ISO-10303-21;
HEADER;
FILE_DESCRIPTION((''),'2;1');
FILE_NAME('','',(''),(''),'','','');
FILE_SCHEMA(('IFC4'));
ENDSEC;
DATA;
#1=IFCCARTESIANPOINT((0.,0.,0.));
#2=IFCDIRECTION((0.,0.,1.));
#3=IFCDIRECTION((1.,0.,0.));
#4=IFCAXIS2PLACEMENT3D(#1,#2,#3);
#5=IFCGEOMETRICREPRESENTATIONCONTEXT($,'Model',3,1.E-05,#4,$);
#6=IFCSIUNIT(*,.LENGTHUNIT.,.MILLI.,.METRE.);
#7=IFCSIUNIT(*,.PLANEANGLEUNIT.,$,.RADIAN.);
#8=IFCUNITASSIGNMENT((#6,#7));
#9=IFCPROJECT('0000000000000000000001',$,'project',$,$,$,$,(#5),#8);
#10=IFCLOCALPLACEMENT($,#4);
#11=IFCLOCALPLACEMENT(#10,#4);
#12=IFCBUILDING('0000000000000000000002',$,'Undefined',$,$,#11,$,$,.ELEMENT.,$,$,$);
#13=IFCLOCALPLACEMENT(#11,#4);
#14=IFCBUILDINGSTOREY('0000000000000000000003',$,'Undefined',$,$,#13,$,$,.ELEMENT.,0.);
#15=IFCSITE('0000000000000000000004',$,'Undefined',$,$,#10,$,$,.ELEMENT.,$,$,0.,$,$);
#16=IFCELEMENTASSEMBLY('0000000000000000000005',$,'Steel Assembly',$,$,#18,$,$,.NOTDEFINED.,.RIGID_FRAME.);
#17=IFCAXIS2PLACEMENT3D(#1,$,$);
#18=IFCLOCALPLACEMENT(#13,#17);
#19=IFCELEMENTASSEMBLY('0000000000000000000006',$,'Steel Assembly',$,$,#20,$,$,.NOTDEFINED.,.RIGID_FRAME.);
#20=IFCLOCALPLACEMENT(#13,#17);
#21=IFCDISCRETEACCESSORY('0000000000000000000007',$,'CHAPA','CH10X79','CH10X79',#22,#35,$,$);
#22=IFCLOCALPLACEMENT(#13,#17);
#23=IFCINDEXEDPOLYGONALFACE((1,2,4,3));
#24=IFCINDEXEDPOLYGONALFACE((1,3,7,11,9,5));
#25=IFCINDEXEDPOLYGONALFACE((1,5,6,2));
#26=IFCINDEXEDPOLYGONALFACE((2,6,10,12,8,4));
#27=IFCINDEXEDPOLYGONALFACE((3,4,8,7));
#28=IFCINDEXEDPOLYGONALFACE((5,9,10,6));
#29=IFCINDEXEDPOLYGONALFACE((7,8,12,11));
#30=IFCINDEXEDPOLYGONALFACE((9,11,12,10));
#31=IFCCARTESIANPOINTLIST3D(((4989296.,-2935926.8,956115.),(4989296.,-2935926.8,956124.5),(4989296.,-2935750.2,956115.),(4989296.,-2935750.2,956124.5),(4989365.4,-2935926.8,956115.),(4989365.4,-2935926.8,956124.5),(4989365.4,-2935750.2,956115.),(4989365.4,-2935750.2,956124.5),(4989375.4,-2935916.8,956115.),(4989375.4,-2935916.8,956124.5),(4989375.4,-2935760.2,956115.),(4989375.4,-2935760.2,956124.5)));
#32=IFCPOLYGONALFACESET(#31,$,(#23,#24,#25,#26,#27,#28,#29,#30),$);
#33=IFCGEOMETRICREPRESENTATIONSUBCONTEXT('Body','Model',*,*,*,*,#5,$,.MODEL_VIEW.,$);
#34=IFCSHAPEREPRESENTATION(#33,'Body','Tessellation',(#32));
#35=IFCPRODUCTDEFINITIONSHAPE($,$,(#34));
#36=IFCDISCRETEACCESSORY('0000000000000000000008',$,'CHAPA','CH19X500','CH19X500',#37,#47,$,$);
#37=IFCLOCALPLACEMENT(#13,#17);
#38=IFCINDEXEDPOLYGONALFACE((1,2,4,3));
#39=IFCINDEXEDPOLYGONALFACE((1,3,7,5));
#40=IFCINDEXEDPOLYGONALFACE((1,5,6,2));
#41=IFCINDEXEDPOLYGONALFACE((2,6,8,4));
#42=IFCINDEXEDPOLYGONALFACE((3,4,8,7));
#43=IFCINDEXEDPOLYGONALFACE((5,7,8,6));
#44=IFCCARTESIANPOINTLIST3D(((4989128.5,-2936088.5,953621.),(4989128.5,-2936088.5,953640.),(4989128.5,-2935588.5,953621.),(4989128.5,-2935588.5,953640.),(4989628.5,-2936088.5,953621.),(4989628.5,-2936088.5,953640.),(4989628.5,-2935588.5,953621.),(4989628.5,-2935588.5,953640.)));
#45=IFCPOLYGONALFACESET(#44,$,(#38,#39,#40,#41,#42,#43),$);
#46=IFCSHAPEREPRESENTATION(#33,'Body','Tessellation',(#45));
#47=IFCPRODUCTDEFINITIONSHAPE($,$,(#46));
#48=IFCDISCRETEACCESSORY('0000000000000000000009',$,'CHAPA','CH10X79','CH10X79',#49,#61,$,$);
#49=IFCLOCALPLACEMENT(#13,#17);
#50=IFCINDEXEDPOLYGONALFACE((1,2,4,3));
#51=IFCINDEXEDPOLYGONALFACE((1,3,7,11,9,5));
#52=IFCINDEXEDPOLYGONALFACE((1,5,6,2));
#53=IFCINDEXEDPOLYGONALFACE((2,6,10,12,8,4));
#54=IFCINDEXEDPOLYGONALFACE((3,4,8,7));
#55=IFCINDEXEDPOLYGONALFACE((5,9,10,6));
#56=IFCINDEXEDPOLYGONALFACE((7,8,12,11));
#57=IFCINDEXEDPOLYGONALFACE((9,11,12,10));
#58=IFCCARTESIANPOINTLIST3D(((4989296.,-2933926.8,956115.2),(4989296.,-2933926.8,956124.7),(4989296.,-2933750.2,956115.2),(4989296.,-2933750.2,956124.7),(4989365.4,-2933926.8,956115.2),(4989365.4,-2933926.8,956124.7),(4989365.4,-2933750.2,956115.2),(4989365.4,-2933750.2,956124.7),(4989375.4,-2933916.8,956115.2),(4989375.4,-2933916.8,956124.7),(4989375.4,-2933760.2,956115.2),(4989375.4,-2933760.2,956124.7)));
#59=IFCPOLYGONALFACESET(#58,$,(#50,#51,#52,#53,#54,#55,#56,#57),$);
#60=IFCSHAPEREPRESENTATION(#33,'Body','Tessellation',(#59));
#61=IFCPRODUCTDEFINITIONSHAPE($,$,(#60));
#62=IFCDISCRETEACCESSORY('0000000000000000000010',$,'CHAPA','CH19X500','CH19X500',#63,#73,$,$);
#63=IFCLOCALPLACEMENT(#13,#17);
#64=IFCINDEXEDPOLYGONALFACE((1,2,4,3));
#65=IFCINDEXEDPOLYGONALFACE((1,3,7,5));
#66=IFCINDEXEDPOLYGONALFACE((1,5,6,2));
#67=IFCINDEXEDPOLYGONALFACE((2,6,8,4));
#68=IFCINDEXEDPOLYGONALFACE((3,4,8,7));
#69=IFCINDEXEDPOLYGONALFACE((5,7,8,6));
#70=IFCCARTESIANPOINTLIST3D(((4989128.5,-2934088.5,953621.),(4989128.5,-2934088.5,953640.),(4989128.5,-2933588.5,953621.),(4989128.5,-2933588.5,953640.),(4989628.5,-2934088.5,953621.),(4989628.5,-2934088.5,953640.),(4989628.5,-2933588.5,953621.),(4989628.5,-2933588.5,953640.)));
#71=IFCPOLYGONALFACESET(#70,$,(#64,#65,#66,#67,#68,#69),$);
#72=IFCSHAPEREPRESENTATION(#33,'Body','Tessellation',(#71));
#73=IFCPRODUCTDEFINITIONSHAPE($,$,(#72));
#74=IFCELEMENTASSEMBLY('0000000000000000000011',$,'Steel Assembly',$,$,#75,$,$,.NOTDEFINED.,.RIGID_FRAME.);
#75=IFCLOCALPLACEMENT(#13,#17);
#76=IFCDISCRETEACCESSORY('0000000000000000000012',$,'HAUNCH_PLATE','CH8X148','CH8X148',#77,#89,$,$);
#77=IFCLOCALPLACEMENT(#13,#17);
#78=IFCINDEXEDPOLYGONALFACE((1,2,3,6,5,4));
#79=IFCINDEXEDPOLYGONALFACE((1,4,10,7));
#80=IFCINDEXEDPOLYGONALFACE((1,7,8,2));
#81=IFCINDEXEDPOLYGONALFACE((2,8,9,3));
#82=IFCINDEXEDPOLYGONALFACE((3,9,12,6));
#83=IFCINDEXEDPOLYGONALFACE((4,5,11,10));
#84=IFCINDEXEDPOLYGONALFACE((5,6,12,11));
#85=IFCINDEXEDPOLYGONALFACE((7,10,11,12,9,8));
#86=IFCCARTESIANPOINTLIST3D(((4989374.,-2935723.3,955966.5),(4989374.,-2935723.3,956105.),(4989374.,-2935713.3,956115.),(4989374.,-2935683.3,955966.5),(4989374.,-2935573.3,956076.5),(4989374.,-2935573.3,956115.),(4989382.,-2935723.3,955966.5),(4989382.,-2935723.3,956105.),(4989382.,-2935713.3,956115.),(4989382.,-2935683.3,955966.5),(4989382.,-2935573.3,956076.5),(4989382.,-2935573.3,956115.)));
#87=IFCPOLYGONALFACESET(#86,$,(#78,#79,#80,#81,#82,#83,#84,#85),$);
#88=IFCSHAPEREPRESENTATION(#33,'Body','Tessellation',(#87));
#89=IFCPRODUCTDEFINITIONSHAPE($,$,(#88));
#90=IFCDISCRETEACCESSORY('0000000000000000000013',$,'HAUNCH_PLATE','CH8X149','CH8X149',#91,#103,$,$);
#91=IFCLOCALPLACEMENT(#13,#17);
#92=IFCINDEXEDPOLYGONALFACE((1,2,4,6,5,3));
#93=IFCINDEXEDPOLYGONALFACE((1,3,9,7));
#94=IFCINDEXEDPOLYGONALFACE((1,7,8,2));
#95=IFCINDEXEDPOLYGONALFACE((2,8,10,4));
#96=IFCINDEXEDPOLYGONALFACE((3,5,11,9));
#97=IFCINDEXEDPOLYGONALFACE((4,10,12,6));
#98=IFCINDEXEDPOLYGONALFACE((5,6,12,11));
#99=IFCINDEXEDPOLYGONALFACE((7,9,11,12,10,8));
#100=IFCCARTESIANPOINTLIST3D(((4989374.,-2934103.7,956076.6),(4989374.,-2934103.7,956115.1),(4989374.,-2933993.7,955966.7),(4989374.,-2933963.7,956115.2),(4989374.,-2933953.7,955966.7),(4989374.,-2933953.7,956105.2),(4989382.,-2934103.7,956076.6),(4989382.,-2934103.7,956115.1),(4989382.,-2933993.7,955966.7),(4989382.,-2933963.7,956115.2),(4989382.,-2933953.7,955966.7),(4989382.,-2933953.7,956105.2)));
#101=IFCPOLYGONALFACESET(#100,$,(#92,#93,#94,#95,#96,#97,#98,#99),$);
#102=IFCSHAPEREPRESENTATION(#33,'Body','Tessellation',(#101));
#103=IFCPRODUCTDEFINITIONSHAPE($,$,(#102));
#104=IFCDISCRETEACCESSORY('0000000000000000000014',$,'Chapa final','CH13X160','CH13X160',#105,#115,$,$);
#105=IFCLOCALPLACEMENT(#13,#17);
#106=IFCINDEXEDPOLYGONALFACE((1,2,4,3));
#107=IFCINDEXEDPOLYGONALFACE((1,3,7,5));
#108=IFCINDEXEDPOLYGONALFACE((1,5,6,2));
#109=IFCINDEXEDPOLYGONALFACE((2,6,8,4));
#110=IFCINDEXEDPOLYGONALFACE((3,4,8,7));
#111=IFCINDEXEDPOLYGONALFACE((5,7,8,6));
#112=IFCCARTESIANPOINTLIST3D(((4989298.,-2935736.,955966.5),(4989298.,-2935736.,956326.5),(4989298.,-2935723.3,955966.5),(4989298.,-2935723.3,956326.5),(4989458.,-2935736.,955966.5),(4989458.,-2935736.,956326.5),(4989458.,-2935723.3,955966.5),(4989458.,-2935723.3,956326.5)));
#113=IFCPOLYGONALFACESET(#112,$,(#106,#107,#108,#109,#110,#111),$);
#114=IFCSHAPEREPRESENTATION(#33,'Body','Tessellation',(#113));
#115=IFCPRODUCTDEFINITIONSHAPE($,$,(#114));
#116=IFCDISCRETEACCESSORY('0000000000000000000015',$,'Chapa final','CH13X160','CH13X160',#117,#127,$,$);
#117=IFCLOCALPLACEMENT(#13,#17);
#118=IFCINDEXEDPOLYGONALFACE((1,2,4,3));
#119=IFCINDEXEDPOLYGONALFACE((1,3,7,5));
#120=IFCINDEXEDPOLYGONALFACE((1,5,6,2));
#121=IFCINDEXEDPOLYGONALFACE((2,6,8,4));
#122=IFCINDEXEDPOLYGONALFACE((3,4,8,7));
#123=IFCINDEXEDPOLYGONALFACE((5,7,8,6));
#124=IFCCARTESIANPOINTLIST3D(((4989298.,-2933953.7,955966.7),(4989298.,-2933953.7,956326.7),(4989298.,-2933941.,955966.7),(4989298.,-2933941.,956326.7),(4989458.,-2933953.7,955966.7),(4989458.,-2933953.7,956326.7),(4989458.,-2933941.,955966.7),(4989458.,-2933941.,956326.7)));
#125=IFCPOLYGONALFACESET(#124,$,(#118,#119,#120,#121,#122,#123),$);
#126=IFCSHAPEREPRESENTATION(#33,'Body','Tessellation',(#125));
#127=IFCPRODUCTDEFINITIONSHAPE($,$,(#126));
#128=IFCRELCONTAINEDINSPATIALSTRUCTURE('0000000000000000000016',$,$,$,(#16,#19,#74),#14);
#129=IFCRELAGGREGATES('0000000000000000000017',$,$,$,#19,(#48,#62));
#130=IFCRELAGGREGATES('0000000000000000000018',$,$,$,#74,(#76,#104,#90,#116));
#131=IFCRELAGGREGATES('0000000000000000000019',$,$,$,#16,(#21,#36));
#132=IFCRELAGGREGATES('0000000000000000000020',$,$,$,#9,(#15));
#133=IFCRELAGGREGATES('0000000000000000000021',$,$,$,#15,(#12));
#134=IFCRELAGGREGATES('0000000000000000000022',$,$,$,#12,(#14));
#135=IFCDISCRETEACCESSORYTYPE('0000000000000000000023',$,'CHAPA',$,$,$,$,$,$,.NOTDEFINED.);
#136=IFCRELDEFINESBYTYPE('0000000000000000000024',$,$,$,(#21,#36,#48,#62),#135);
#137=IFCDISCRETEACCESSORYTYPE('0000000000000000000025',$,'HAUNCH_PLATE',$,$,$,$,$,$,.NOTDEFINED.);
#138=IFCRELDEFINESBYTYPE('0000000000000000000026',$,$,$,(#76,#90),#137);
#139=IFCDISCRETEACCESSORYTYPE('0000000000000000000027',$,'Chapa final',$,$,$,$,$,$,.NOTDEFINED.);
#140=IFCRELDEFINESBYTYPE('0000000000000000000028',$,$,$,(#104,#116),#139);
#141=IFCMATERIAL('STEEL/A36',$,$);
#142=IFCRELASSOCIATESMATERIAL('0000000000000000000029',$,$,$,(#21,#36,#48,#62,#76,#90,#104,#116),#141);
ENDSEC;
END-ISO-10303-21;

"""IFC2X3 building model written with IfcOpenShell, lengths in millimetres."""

from ifc_helpers import new_model, si_unit, frame, origin_with_axes, place, context, subcontext, project, spatial, polyline, outline, extrude, material, type_object, element, aggregate, save


model = new_model("IFC2X3")

# Units and contexts
model_context = context("Model", 3, precision=1e-05, world=origin_with_axes())
body_context = subcontext(model_context, "Body", "Model", "MODEL_VIEW")
ifc_project = project(units=[si_unit("LENGTHUNIT", "METRE", prefix="MILLI"), si_unit("PLANEANGLEUNIT", "RADIAN")], contexts=[model_context])

# Site, building, storey
site_placement = place(None, origin_with_axes())
site = spatial("IfcSite", under=ifc_project, at=site_placement, Name="Undefined", CompositionType="ELEMENT", RefElevation=0.0)
building_placement = place(site_placement, origin_with_axes())
building = spatial("IfcBuilding", under=site, at=building_placement, Name="Undefined", CompositionType="ELEMENT")
storey_placement = place(building_placement, origin_with_axes())
storey = spatial("IfcBuildingStorey", under=building, at=storey_placement, Name="Undefined", CompositionType="ELEMENT", Elevation=0.0)

# Element assemblies
assembly_1_placement = place(storey_placement, origin_with_axes())
assembly_1 = element("IfcElementAssembly", 1, at=assembly_1_placement, inside=storey, Name="Steel Assembly", AssemblyPlace="NOTDEFINED", PredefinedType="RIGID_FRAME")
assembly_2_placement = place(storey_placement, origin_with_axes())
assembly_2 = element("IfcElementAssembly", 2, at=assembly_2_placement, inside=storey, Name="Steel Assembly", AssemblyPlace="NOTDEFINED", PredefinedType="RIGID_FRAME")

# Discrete accessories
ifc_material_1 = material(Name="STEEL/A36")
discrete_accessory_type_1 = type_object("IfcDiscreteAccessoryType", Name="CHAPA")
discrete_accessory_1_placement = place(assembly_1_placement, frame((4989296.0, -2935750.2, 956119.8), z_axis=(0.0, 0.0, -1.0), x_axis=(1.0, 0.0, 0.0)))
discrete_accessory_1 = element("IfcDiscreteAccessory", 3, at=discrete_accessory_1_placement, type_object=discrete_accessory_type_1, material=ifc_material_1, Name="CHAPA", Description="CH10X79", ObjectType="CH10X79", context=body_context, shape_type="SweptSolid", body=[
    extrude(outline(polyline([(0.0, 0.0), (69.4, 0.0), (79.4, 10.0), (79.4, 166.6), (69.4, 176.6), (0.0, 176.6), (0.0, 0.0)])), frame((0.0, 0.0, -4.8), z_axis=(0.0, 0.0, 1.0), x_axis=(1.0, 0.0, 0.0)), (0.0, 0.0, 1.0), 9.5),
])
discrete_accessory_2_placement = place(assembly_1_placement, frame((4989378.5, -2935588.5, 953630.5), z_axis=(0.0, 0.0, 1.0), x_axis=(0.0, -1.0, 0.0)))
discrete_accessory_2 = element("IfcDiscreteAccessory", 4, at=discrete_accessory_2_placement, type_object=discrete_accessory_type_1, material=ifc_material_1, Name="CHAPA", Description="CH19X500", ObjectType="CH19X500", context=body_context, shape_type="SweptSolid", body=[
    extrude(outline(polyline([(500.0, -250.0), (0.0, -250.0), (0.0, 250.0), (500.0, 250.0), (500.0, -250.0)])), frame((0.0, 0.0, -9.5), z_axis=(0.0, 0.0, 1.0), x_axis=(1.0, 0.0, 0.0)), (0.0, 0.0, 1.0), 19.0),
])
discrete_accessory_3_placement = place(assembly_2_placement, frame((4989375.4, -2933926.8, 956119.9), z_axis=(0.0, 0.0, -1.0), x_axis=(-1.0, 0.0, 0.0)))
discrete_accessory_3 = element("IfcDiscreteAccessory", 5, at=discrete_accessory_3_placement, type_object=discrete_accessory_type_1, material=ifc_material_1, Name="CHAPA", Description="CH10X79", ObjectType="CH10X79", context=body_context, shape_type="SweptSolid", body=[
    extrude(outline(polyline([(0.0, 10.0), (10.0, 0.0), (79.4, 0.0), (79.4, 176.6), (10.0, 176.6), (0.0, 166.6), (0.0, 10.0)])), frame((0.0, 0.0, -4.8), z_axis=(0.0, 0.0, 1.0), x_axis=(1.0, 0.0, 0.0)), (0.0, 0.0, 1.0), 9.5),
])
discrete_accessory_4_placement = place(assembly_2_placement, frame((4989378.5, -2933588.5, 953630.5), z_axis=(0.0, 0.0, 1.0), x_axis=(0.0, -1.0, 0.0)))
discrete_accessory_4 = element("IfcDiscreteAccessory", 6, at=discrete_accessory_4_placement, type_object=discrete_accessory_type_1, material=ifc_material_1, Name="CHAPA", Description="CH19X500", ObjectType="CH19X500", context=body_context, shape_type="SweptSolid", body=[
    extrude(outline(polyline([(500.0, -250.0), (0.0, -250.0), (0.0, 250.0), (500.0, 250.0), (500.0, -250.0)])), frame((0.0, 0.0, -9.5), z_axis=(0.0, 0.0, 1.0), x_axis=(1.0, 0.0, 0.0)), (0.0, 0.0, 1.0), 19.0),
])
aggregate(assembly_2, [discrete_accessory_3, discrete_accessory_4])

# Element assembly, discrete accessories
assembly_3_placement = place(storey_placement, origin_with_axes())
assembly_3 = element("IfcElementAssembly", 7, at=assembly_3_placement, inside=storey, Name="Steel Assembly", AssemblyPlace="NOTDEFINED", PredefinedType="RIGID_FRAME")
discrete_accessory_type_2 = type_object("IfcDiscreteAccessoryType", Name="HAUNCH_PLATE")
discrete_accessory_5_placement = place(assembly_3_placement, frame((4989378.0, -2935723.3, 956115.0), z_axis=(1.0, 0.0, 0.0), x_axis=(0.0, 0.0, -1.0)))
discrete_accessory_5 = element("IfcDiscreteAccessory", 8, at=discrete_accessory_5_placement, type_object=discrete_accessory_type_2, material=ifc_material_1, Name="HAUNCH_PLATE", Description="CH8X148", ObjectType="CH8X148", context=body_context, shape_type="SweptSolid", body=[
    extrude(outline(polyline([(0.0, 10.0), (10.0, 0.0), (148.5, 0.0), (148.5, 40.0), (38.5, 150.0), (0.0, 150.0), (0.0, 10.0)])), frame((0.0, 0.0, -4.0), z_axis=(0.0, 0.0, 1.0), x_axis=(1.0, 0.0, 0.0)), (0.0, 0.0, 1.0), 8.0),
])
discrete_accessory_6_placement = place(assembly_3_placement, frame((4989378.0, -2933953.7, 956115.2), z_axis=(-1.0, 0.0, 0.0), x_axis=(0.0, 0.0, -1.0)))
discrete_accessory_6 = element("IfcDiscreteAccessory", 9, at=discrete_accessory_6_placement, type_object=discrete_accessory_type_2, material=ifc_material_1, Name="HAUNCH_PLATE", Description="CH8X149", ObjectType="CH8X149", context=body_context, shape_type="SweptSolid", body=[
    extrude(outline(polyline([(0.0, 10.0), (10.0, 0.0), (148.5, 0.0), (148.5, 40.0), (38.5, 150.0), (0.0, 150.0), (0.0, 10.0)])), frame((0.0, 0.0, -4.0), z_axis=(0.0, 0.0, 1.0), x_axis=(1.0, 0.0, 0.0)), (0.0, 0.0, 1.0), 8.0),
])
discrete_accessory_type_3 = type_object("IfcDiscreteAccessoryType", Name="Chapa final")
discrete_accessory_7_placement = place(assembly_3_placement, frame((4989378.0, -2935729.7, 955966.5), z_axis=(0.0, 1.0, 0.0), x_axis=(0.0, 0.0, 1.0)))
discrete_accessory_7 = element("IfcDiscreteAccessory", 10, at=discrete_accessory_7_placement, type_object=discrete_accessory_type_3, material=ifc_material_1, Name="Chapa final", Description="CH13X160", ObjectType="CH13X160", context=body_context, shape_type="SweptSolid", body=[
    extrude(outline(polyline([(0.0, -80.0), (0.0, 80.0), (360.0, 80.0), (360.0, -80.0), (0.0, -80.0)])), frame((0.0, 0.0, -6.3), z_axis=(0.0, 0.0, 1.0), x_axis=(1.0, 0.0, 0.0)), (0.0, 0.0, 1.0), 12.7),
])
discrete_accessory_8_placement = place(assembly_3_placement, frame((4989378.0, -2933947.4, 955966.7), z_axis=(0.0, -1.0, 0.0), x_axis=(0.0, 0.0, 1.0)))
discrete_accessory_8 = element("IfcDiscreteAccessory", 11, at=discrete_accessory_8_placement, type_object=discrete_accessory_type_3, material=ifc_material_1, Name="Chapa final", Description="CH13X160", ObjectType="CH13X160", context=body_context, shape_type="SweptSolid", body=[
    extrude(outline(polyline([(0.0, 80.0), (360.0, 80.0), (360.0, -80.0), (0.0, -80.0), (0.0, 80.0)])), frame((0.0, 0.0, -6.3), z_axis=(0.0, 0.0, 1.0), x_axis=(1.0, 0.0, 0.0)), (0.0, 0.0, 1.0), 12.7),
])
aggregate(assembly_3, [discrete_accessory_5, discrete_accessory_7, discrete_accessory_6, discrete_accessory_8])

aggregate(assembly_1, [discrete_accessory_1, discrete_accessory_2])

save(model, "model.ifc")
